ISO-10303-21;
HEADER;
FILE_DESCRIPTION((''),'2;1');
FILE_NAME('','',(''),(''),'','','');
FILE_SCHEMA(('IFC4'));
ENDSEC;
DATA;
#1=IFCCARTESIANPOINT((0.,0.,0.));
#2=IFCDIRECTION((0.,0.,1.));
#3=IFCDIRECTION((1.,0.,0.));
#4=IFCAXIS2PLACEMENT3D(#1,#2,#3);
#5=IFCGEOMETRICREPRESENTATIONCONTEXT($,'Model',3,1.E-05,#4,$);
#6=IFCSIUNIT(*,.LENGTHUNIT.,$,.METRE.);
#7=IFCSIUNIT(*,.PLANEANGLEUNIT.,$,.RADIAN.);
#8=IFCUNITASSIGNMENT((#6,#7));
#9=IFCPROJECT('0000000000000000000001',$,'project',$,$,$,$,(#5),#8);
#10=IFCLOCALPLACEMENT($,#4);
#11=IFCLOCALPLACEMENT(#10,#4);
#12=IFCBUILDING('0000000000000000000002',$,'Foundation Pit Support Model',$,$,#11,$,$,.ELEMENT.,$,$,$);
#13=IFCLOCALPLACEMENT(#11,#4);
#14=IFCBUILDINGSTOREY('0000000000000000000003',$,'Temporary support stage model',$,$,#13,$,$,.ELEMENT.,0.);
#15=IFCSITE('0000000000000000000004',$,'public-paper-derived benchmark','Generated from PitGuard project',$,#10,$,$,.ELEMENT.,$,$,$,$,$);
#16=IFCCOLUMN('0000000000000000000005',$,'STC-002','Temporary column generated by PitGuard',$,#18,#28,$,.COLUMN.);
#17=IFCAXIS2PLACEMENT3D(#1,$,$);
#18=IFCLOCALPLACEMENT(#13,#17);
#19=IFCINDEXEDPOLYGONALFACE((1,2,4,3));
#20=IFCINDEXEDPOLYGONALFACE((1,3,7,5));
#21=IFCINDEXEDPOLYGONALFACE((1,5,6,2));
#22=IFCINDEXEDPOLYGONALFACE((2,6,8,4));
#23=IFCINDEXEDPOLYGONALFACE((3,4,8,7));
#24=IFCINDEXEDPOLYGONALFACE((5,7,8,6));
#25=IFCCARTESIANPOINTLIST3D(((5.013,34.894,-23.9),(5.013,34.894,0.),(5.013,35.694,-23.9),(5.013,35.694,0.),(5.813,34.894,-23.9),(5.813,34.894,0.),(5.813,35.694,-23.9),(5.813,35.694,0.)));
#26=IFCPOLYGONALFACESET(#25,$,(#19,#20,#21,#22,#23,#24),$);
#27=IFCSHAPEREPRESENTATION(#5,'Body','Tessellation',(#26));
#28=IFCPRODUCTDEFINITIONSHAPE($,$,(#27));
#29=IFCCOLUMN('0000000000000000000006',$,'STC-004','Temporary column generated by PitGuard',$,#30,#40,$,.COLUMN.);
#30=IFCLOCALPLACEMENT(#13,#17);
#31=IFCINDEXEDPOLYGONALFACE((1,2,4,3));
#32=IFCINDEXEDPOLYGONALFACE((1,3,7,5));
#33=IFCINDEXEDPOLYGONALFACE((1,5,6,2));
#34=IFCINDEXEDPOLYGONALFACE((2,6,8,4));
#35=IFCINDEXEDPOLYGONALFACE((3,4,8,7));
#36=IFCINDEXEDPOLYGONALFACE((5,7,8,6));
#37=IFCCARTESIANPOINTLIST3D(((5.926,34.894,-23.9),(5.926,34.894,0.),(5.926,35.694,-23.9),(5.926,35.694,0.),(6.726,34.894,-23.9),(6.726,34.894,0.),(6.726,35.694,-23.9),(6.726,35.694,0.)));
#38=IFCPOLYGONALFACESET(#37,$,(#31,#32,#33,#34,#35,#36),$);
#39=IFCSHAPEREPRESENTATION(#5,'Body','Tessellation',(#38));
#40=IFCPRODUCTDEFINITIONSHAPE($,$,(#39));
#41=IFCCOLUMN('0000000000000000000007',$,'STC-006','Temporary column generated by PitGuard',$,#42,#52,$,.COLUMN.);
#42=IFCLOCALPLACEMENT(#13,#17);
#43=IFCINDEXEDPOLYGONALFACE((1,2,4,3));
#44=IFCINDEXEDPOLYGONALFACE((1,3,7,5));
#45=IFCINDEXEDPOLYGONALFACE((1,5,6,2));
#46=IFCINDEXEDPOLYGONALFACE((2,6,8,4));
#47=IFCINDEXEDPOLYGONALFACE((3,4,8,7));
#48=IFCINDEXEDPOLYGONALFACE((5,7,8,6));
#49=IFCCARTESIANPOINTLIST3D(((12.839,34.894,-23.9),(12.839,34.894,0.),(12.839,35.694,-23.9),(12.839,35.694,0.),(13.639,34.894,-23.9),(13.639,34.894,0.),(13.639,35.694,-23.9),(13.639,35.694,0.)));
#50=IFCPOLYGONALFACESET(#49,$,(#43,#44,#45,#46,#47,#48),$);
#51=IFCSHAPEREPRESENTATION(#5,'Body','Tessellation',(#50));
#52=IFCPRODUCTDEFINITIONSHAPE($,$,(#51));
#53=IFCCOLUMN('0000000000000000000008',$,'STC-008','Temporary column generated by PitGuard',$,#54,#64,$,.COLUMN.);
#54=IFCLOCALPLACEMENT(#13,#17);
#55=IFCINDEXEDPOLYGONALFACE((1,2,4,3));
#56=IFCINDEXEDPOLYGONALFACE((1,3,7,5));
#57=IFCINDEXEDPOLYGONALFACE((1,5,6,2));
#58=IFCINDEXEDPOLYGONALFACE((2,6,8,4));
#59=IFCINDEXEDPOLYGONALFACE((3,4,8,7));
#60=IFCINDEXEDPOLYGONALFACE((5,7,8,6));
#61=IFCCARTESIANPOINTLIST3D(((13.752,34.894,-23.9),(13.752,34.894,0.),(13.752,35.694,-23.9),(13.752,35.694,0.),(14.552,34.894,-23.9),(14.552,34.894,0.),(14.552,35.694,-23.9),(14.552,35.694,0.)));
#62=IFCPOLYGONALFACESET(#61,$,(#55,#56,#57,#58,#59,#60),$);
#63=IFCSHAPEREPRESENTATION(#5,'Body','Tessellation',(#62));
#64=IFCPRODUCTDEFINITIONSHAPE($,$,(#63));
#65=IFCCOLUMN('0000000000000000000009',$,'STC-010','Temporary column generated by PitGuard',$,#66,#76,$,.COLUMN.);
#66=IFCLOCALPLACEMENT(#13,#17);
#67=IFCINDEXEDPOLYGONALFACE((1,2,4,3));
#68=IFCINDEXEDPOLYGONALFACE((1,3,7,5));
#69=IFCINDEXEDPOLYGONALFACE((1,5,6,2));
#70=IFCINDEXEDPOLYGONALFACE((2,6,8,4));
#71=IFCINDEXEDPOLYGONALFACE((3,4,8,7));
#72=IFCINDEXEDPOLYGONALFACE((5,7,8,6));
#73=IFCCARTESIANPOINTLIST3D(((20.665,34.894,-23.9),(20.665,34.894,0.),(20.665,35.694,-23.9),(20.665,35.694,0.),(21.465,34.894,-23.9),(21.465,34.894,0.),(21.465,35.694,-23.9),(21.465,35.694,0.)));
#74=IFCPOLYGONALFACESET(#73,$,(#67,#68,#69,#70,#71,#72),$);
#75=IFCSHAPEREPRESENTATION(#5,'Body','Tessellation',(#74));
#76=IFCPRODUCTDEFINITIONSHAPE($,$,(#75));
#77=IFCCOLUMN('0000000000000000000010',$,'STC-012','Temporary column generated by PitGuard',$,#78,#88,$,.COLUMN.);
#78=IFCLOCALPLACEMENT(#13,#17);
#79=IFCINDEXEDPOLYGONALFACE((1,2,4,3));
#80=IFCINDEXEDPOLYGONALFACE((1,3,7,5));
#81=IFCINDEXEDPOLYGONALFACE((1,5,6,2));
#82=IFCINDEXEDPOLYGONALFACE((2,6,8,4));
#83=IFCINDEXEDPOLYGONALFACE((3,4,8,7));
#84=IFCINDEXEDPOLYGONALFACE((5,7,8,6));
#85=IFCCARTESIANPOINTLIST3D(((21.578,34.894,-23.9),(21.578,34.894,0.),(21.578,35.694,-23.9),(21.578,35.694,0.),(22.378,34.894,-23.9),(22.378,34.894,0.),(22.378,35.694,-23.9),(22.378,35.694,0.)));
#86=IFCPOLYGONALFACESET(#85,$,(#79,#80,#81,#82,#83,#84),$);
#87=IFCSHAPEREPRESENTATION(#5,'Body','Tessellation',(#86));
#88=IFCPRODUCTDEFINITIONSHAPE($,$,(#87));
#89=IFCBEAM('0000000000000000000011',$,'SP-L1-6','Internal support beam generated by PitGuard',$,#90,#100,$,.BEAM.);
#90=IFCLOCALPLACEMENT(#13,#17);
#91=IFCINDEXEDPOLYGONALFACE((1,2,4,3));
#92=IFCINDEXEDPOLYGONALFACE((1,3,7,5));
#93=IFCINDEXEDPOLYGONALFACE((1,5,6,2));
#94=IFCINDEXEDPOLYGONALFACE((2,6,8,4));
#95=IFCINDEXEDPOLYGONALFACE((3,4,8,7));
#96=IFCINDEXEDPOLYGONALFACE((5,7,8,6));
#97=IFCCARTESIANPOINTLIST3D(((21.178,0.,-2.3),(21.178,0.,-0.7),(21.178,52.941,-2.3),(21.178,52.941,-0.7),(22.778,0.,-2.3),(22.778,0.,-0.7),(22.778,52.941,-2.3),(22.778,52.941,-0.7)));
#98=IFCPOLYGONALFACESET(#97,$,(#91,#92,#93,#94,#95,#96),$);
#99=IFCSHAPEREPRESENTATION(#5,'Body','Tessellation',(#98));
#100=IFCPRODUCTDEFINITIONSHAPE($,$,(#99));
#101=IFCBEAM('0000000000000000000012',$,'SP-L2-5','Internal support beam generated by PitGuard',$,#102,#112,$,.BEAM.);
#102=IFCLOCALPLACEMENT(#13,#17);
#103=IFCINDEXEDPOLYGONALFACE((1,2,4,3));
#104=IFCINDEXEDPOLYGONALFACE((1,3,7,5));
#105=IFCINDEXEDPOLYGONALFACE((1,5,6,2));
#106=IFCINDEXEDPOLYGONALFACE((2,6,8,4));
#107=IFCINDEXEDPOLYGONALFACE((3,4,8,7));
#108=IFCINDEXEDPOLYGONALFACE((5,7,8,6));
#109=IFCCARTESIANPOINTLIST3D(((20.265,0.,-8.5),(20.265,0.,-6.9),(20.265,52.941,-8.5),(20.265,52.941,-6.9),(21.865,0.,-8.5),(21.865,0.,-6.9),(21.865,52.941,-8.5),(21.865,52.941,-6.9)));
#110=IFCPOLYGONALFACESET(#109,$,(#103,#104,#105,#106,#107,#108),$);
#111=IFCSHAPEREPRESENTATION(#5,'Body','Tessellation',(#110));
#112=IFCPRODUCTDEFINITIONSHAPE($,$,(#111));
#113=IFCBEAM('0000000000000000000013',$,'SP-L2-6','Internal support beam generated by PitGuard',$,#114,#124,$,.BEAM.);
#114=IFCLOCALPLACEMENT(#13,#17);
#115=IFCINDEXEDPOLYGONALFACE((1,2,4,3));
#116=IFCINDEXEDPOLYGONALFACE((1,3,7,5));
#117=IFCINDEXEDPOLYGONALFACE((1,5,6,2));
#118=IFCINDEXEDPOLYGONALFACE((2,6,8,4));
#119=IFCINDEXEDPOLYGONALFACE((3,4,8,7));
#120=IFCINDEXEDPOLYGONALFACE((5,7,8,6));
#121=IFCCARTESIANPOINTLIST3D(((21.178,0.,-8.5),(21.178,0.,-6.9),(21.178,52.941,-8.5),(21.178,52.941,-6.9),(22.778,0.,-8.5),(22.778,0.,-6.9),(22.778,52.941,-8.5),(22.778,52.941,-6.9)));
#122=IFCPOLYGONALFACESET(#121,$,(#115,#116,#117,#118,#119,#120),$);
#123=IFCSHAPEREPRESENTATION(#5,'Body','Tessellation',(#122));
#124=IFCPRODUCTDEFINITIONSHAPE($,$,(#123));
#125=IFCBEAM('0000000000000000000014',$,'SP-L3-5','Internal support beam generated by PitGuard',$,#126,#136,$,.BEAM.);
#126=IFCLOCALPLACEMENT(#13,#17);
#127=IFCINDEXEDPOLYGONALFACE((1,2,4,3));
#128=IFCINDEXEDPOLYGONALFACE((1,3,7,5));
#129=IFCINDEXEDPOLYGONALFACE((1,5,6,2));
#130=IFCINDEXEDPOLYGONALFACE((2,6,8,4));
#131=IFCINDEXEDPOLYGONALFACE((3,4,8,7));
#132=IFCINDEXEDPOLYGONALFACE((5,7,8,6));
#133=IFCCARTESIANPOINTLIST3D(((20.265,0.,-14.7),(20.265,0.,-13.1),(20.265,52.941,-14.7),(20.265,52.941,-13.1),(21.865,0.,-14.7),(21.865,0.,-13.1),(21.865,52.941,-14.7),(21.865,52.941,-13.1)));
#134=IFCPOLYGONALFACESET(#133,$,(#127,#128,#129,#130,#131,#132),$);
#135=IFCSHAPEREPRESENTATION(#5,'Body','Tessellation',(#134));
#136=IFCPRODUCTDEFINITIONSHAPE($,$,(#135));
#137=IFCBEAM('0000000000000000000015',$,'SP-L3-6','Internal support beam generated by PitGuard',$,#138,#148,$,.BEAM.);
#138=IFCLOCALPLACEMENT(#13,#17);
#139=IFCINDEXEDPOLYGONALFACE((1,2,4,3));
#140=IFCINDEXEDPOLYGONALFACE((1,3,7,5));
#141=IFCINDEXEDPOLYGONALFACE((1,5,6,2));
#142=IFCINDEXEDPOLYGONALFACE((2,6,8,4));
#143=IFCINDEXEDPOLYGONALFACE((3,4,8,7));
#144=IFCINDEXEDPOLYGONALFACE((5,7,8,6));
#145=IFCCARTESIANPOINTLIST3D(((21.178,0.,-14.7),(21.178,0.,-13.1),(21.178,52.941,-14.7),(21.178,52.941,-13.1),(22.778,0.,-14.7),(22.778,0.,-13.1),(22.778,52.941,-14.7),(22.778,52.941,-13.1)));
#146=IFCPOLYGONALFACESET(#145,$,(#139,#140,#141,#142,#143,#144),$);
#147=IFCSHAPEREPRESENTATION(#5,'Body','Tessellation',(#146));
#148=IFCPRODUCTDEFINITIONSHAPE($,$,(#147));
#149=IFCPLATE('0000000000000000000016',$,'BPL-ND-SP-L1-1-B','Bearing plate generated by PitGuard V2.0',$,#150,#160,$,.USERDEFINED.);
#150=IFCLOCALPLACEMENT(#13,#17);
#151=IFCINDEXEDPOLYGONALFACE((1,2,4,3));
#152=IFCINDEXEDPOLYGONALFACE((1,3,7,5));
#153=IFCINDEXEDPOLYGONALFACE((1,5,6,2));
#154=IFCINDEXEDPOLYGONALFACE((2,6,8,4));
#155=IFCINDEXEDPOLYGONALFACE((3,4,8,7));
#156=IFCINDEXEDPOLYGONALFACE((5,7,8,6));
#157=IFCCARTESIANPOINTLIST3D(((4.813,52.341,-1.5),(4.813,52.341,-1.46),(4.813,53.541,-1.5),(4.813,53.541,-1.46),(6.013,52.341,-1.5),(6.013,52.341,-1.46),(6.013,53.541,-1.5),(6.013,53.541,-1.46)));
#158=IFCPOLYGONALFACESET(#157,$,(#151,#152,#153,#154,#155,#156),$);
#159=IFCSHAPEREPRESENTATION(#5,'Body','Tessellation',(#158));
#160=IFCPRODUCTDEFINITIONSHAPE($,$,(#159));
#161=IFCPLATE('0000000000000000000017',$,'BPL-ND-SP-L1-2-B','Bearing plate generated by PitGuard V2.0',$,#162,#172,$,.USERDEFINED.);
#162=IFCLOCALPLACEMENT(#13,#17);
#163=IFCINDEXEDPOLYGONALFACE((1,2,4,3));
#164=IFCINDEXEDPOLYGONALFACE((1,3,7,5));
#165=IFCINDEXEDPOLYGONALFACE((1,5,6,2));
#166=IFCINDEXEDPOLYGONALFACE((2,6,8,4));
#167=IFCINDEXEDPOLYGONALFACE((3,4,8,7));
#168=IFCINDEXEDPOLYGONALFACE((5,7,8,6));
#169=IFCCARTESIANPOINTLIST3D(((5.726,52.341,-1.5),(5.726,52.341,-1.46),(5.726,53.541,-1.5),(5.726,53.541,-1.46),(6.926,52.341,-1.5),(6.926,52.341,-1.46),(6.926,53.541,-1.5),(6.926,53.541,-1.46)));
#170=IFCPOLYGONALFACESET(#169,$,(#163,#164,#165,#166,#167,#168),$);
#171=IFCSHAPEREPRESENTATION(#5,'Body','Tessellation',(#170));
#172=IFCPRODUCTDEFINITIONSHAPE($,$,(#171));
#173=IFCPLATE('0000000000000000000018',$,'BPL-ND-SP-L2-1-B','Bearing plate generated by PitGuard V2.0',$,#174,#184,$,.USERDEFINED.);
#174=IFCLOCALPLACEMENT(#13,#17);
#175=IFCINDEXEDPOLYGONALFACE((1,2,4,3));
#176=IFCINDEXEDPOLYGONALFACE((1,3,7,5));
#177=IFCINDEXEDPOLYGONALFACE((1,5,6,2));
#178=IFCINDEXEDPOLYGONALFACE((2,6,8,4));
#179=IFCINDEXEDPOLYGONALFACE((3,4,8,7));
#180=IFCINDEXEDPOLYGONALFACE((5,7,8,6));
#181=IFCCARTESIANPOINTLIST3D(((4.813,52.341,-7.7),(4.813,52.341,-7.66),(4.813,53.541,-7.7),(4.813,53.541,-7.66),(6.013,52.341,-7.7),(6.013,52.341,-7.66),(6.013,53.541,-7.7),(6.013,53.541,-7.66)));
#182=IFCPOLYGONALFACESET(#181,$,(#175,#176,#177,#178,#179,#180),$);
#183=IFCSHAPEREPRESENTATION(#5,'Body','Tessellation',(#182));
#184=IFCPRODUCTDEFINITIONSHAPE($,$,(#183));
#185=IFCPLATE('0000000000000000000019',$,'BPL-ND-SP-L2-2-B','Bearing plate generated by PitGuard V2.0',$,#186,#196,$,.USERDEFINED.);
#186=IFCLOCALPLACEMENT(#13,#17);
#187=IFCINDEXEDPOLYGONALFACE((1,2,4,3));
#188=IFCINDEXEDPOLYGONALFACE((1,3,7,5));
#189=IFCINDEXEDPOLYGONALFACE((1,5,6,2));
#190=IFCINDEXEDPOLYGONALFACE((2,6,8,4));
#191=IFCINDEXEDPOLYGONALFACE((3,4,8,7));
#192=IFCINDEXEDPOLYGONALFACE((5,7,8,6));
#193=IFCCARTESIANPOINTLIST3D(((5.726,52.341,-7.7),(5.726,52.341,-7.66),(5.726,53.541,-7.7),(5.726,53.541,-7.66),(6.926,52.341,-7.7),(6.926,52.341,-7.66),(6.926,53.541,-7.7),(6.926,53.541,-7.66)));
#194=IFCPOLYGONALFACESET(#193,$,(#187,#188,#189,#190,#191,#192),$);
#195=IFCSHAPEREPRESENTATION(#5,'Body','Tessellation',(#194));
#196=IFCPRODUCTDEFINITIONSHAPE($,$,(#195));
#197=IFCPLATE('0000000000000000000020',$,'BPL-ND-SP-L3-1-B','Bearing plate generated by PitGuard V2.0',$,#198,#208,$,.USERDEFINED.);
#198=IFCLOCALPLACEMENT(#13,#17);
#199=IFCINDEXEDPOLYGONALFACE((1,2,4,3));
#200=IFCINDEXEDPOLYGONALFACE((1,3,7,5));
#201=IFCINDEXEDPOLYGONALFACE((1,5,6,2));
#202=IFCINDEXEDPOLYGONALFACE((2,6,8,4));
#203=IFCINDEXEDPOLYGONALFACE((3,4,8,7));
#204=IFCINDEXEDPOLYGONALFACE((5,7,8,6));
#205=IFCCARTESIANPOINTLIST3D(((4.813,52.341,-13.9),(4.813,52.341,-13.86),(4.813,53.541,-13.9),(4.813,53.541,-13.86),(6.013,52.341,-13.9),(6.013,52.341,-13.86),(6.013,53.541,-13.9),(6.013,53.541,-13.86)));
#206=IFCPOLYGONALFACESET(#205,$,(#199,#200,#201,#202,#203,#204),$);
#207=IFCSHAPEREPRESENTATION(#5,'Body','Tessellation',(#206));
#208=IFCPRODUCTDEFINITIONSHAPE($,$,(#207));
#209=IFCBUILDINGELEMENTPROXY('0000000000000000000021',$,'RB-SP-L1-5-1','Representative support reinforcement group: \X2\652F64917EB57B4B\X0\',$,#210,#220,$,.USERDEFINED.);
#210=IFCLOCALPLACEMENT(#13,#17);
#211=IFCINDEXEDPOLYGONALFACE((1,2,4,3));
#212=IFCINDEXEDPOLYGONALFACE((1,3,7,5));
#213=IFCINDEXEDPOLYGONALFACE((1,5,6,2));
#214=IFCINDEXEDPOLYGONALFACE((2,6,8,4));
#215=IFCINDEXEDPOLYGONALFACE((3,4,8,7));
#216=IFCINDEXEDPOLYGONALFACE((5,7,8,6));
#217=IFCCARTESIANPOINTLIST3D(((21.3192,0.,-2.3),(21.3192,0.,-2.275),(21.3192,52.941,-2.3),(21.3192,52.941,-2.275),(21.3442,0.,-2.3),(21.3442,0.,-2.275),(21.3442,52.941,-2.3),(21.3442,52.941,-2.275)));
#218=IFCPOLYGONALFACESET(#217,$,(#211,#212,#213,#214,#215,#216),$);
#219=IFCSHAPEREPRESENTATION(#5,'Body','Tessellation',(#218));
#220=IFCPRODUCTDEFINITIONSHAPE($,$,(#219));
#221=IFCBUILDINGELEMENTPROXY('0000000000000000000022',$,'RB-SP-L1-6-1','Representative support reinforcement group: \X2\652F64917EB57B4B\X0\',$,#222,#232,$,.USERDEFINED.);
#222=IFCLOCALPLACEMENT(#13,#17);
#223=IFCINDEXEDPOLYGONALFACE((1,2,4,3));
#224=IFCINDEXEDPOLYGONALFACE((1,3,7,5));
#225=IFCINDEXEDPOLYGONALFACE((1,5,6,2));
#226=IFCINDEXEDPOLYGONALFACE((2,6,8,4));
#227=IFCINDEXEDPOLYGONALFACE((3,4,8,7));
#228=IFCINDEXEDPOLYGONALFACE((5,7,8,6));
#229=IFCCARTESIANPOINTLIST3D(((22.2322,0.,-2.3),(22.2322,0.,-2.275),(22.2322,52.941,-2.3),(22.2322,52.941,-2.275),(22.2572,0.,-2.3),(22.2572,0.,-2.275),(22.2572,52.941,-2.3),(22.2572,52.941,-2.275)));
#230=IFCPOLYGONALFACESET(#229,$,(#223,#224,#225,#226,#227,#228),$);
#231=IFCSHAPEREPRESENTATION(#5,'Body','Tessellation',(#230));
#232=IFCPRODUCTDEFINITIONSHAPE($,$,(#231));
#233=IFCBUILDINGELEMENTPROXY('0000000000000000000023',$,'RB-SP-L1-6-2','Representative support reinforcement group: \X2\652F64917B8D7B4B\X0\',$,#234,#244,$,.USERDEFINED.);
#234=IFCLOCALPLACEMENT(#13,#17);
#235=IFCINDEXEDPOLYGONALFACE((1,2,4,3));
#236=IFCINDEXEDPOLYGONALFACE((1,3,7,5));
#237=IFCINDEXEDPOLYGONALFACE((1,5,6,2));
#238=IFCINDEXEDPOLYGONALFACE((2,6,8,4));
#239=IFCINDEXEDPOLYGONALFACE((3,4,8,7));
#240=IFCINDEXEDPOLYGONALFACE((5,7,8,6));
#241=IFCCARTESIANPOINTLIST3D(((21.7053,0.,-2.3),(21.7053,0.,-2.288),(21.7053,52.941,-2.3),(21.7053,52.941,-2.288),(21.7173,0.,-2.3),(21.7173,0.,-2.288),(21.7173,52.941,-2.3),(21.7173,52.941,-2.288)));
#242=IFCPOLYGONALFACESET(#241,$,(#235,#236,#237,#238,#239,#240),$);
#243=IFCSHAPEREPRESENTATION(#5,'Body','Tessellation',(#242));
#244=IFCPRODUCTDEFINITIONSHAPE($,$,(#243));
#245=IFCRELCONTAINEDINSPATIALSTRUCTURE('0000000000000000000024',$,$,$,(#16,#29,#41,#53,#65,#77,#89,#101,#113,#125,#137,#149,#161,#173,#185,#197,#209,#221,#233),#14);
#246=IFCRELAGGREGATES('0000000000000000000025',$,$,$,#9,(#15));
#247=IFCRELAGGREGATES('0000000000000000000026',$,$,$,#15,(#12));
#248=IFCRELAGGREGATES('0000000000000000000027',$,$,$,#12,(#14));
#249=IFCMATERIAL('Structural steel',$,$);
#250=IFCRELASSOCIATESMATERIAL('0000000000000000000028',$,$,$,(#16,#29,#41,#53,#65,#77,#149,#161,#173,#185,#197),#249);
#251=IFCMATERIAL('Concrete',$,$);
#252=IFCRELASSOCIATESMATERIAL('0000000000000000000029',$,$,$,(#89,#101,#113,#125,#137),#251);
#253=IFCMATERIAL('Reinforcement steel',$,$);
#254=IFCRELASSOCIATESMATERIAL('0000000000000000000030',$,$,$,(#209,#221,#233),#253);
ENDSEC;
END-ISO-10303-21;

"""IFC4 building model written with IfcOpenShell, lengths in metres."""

from ifc_helpers import new_model, si_unit, frame, origin_with_axes, origin_2d, place, context, project, spatial, rectangle, extrude, material, element, save


model = new_model("IFC4")

# Units and contexts
model_context = context("Model", 3, precision=1e-05, world=origin_with_axes())
ifc_project = project(units=[si_unit("LENGTHUNIT", "METRE"), si_unit("PLANEANGLEUNIT", "RADIAN")], contexts=[model_context])

# Site, building, storey
site_placement = place(None, origin_with_axes())
site = spatial("IfcSite", under=ifc_project, at=site_placement, Name="public-paper-derived benchmark", Description="Generated from PitGuard project", CompositionType="ELEMENT")
building_placement = place(site_placement, origin_with_axes())
building = spatial("IfcBuilding", under=site, at=building_placement, Name="Foundation Pit Support Model", CompositionType="ELEMENT")
storey_placement = place(building_placement, origin_with_axes())
storey = spatial("IfcBuildingStorey", under=building, at=storey_placement, Name="Temporary support stage model", CompositionType="ELEMENT", Elevation=0.0)

# Columns
ifc_material_1 = material(Name="Structural steel")
for number, where, z_axis, x_axis, name in (
    (1, (5.413, 35.294, -23.9), (0.0, 0.0, 1.0), (1.0, 0.0, 0.0), "STC-002"),
    (2, (6.326, 35.294, -23.9), (0.0, 0.0, 1.0), (1.0, 0.0, 0.0), "STC-004"),
    (3, (13.239, 35.294, -23.9), (0.0, 0.0, 1.0), (1.0, 0.0, 0.0), "STC-006"),
    (4, (14.152, 35.294, -23.9), (0.0, 0.0, 1.0), (1.0, 0.0, 0.0), "STC-008"),
    (5, (21.065, 35.294, -23.9), (0.0, 0.0, 1.0), (1.0, 0.0, 0.0), "STC-010"),
    (6, (21.978, 35.294, -23.9), (0.0, 0.0, 1.0), (1.0, 0.0, 0.0), "STC-012"),
):
    element("IfcColumn", number, at=place(storey_placement, frame(where, z_axis=z_axis, x_axis=x_axis)), inside=storey, material=ifc_material_1, Name=name, Description="Temporary column generated by PitGuard", PredefinedType="COLUMN", context=model_context, shape_type="SweptSolid", body=[
        extrude(rectangle(XDim=0.8, YDim=0.8, at=origin_2d()), origin_with_axes(), (0.0, 0.0, 1.0), 23.9),
    ])

# Beams
ifc_material_2 = material(Name="Concrete")
for number, where, z_axis, x_axis, name in (
    (7, (21.978, 26.4705, -2.3), (0.0, 0.0, 1.0), (0.0, 1.0, 0.0), "SP-L1-6"),
    (8, (21.065, 26.4705, -8.5), (0.0, 0.0, 1.0), (0.0, 1.0, 0.0), "SP-L2-5"),
    (9, (21.978, 26.4705, -8.5), (0.0, 0.0, 1.0), (0.0, 1.0, 0.0), "SP-L2-6"),
    (10, (21.065, 26.4705, -14.7), (0.0, 0.0, 1.0), (0.0, 1.0, 0.0), "SP-L3-5"),
    (11, (21.978, 26.4705, -14.7), (0.0, 0.0, 1.0), (0.0, 1.0, 0.0), "SP-L3-6"),
):
    element("IfcBeam", number, at=place(storey_placement, frame(where, z_axis=z_axis, x_axis=x_axis)), inside=storey, material=ifc_material_2, Name=name, Description="Internal support beam generated by PitGuard", PredefinedType="BEAM", context=model_context, shape_type="SweptSolid", body=[
        extrude(rectangle(XDim=52.941, YDim=1.6, at=origin_2d()), origin_with_axes(), (0.0, 0.0, 1.0), 1.6),
    ])

# Plates
for number, where, z_axis, x_axis, name in (
    (12, (5.413, 52.941, -1.5), (0.0, 0.0, 1.0), (1.0, 0.0, 0.0), "BPL-ND-SP-L1-1-B"),
    (13, (6.326, 52.941, -1.5), (0.0, 0.0, 1.0), (1.0, 0.0, 0.0), "BPL-ND-SP-L1-2-B"),
    (14, (5.413, 52.941, -7.7), (0.0, 0.0, 1.0), (1.0, 0.0, 0.0), "BPL-ND-SP-L2-1-B"),
    (15, (6.326, 52.941, -7.7), (0.0, 0.0, 1.0), (1.0, 0.0, 0.0), "BPL-ND-SP-L2-2-B"),
    (16, (5.413, 52.941, -13.9), (0.0, 0.0, 1.0), (1.0, 0.0, 0.0), "BPL-ND-SP-L3-1-B"),
):
    element("IfcPlate", number, at=place(storey_placement, frame(where, z_axis=z_axis, x_axis=x_axis)), inside=storey, material=ifc_material_1, Name=name, Description="Bearing plate generated by PitGuard V2.0", PredefinedType="USERDEFINED", context=model_context, shape_type="SweptSolid", body=[
        extrude(rectangle(XDim=1.2, YDim=1.2, at=origin_2d()), origin_with_axes(), (0.0, 0.0, 1.0), 0.04),
    ])

# Building element proxies
ifc_material_3 = material(Name="Reinforcement steel")
for number, where, z_axis, x_axis, name in (
    (17, (21.3317, 26.4705, -2.3), (0.0, 0.0, 1.0), (0.0, 1.0, 0.0), "RB-SP-L1-5-1"),
    (18, (22.2447, 26.4705, -2.3), (0.0, 0.0, 1.0), (0.0, 1.0, 0.0), "RB-SP-L1-6-1"),
):
    element("IfcBuildingElementProxy", number, at=place(storey_placement, frame(where, z_axis=z_axis, x_axis=x_axis)), inside=storey, material=ifc_material_3, Name=name, Description="Representative support reinforcement group: 支撑纵筋", PredefinedType="USERDEFINED", context=model_context, shape_type="SweptSolid", body=[
        extrude(rectangle(XDim=52.941, YDim=0.025, at=origin_2d()), origin_with_axes(), (0.0, 0.0, 1.0), 0.025),
    ])
for number, where, z_axis, x_axis, name in (
    (19, (21.7113, 26.4705, -2.3), (0.0, 0.0, 1.0), (0.0, 1.0, 0.0), "RB-SP-L1-6-2"),
):
    element("IfcBuildingElementProxy", number, at=place(storey_placement, frame(where, z_axis=z_axis, x_axis=x_axis)), inside=storey, material=ifc_material_3, Name=name, Description="Representative support reinforcement group: 支撑箍筋", PredefinedType="USERDEFINED", context=model_context, shape_type="SweptSolid", body=[
        extrude(rectangle(XDim=52.941, YDim=0.012, at=origin_2d()), origin_with_axes(), (0.0, 0.0, 1.0), 0.012),
    ])

save(model, "model.ifc")
